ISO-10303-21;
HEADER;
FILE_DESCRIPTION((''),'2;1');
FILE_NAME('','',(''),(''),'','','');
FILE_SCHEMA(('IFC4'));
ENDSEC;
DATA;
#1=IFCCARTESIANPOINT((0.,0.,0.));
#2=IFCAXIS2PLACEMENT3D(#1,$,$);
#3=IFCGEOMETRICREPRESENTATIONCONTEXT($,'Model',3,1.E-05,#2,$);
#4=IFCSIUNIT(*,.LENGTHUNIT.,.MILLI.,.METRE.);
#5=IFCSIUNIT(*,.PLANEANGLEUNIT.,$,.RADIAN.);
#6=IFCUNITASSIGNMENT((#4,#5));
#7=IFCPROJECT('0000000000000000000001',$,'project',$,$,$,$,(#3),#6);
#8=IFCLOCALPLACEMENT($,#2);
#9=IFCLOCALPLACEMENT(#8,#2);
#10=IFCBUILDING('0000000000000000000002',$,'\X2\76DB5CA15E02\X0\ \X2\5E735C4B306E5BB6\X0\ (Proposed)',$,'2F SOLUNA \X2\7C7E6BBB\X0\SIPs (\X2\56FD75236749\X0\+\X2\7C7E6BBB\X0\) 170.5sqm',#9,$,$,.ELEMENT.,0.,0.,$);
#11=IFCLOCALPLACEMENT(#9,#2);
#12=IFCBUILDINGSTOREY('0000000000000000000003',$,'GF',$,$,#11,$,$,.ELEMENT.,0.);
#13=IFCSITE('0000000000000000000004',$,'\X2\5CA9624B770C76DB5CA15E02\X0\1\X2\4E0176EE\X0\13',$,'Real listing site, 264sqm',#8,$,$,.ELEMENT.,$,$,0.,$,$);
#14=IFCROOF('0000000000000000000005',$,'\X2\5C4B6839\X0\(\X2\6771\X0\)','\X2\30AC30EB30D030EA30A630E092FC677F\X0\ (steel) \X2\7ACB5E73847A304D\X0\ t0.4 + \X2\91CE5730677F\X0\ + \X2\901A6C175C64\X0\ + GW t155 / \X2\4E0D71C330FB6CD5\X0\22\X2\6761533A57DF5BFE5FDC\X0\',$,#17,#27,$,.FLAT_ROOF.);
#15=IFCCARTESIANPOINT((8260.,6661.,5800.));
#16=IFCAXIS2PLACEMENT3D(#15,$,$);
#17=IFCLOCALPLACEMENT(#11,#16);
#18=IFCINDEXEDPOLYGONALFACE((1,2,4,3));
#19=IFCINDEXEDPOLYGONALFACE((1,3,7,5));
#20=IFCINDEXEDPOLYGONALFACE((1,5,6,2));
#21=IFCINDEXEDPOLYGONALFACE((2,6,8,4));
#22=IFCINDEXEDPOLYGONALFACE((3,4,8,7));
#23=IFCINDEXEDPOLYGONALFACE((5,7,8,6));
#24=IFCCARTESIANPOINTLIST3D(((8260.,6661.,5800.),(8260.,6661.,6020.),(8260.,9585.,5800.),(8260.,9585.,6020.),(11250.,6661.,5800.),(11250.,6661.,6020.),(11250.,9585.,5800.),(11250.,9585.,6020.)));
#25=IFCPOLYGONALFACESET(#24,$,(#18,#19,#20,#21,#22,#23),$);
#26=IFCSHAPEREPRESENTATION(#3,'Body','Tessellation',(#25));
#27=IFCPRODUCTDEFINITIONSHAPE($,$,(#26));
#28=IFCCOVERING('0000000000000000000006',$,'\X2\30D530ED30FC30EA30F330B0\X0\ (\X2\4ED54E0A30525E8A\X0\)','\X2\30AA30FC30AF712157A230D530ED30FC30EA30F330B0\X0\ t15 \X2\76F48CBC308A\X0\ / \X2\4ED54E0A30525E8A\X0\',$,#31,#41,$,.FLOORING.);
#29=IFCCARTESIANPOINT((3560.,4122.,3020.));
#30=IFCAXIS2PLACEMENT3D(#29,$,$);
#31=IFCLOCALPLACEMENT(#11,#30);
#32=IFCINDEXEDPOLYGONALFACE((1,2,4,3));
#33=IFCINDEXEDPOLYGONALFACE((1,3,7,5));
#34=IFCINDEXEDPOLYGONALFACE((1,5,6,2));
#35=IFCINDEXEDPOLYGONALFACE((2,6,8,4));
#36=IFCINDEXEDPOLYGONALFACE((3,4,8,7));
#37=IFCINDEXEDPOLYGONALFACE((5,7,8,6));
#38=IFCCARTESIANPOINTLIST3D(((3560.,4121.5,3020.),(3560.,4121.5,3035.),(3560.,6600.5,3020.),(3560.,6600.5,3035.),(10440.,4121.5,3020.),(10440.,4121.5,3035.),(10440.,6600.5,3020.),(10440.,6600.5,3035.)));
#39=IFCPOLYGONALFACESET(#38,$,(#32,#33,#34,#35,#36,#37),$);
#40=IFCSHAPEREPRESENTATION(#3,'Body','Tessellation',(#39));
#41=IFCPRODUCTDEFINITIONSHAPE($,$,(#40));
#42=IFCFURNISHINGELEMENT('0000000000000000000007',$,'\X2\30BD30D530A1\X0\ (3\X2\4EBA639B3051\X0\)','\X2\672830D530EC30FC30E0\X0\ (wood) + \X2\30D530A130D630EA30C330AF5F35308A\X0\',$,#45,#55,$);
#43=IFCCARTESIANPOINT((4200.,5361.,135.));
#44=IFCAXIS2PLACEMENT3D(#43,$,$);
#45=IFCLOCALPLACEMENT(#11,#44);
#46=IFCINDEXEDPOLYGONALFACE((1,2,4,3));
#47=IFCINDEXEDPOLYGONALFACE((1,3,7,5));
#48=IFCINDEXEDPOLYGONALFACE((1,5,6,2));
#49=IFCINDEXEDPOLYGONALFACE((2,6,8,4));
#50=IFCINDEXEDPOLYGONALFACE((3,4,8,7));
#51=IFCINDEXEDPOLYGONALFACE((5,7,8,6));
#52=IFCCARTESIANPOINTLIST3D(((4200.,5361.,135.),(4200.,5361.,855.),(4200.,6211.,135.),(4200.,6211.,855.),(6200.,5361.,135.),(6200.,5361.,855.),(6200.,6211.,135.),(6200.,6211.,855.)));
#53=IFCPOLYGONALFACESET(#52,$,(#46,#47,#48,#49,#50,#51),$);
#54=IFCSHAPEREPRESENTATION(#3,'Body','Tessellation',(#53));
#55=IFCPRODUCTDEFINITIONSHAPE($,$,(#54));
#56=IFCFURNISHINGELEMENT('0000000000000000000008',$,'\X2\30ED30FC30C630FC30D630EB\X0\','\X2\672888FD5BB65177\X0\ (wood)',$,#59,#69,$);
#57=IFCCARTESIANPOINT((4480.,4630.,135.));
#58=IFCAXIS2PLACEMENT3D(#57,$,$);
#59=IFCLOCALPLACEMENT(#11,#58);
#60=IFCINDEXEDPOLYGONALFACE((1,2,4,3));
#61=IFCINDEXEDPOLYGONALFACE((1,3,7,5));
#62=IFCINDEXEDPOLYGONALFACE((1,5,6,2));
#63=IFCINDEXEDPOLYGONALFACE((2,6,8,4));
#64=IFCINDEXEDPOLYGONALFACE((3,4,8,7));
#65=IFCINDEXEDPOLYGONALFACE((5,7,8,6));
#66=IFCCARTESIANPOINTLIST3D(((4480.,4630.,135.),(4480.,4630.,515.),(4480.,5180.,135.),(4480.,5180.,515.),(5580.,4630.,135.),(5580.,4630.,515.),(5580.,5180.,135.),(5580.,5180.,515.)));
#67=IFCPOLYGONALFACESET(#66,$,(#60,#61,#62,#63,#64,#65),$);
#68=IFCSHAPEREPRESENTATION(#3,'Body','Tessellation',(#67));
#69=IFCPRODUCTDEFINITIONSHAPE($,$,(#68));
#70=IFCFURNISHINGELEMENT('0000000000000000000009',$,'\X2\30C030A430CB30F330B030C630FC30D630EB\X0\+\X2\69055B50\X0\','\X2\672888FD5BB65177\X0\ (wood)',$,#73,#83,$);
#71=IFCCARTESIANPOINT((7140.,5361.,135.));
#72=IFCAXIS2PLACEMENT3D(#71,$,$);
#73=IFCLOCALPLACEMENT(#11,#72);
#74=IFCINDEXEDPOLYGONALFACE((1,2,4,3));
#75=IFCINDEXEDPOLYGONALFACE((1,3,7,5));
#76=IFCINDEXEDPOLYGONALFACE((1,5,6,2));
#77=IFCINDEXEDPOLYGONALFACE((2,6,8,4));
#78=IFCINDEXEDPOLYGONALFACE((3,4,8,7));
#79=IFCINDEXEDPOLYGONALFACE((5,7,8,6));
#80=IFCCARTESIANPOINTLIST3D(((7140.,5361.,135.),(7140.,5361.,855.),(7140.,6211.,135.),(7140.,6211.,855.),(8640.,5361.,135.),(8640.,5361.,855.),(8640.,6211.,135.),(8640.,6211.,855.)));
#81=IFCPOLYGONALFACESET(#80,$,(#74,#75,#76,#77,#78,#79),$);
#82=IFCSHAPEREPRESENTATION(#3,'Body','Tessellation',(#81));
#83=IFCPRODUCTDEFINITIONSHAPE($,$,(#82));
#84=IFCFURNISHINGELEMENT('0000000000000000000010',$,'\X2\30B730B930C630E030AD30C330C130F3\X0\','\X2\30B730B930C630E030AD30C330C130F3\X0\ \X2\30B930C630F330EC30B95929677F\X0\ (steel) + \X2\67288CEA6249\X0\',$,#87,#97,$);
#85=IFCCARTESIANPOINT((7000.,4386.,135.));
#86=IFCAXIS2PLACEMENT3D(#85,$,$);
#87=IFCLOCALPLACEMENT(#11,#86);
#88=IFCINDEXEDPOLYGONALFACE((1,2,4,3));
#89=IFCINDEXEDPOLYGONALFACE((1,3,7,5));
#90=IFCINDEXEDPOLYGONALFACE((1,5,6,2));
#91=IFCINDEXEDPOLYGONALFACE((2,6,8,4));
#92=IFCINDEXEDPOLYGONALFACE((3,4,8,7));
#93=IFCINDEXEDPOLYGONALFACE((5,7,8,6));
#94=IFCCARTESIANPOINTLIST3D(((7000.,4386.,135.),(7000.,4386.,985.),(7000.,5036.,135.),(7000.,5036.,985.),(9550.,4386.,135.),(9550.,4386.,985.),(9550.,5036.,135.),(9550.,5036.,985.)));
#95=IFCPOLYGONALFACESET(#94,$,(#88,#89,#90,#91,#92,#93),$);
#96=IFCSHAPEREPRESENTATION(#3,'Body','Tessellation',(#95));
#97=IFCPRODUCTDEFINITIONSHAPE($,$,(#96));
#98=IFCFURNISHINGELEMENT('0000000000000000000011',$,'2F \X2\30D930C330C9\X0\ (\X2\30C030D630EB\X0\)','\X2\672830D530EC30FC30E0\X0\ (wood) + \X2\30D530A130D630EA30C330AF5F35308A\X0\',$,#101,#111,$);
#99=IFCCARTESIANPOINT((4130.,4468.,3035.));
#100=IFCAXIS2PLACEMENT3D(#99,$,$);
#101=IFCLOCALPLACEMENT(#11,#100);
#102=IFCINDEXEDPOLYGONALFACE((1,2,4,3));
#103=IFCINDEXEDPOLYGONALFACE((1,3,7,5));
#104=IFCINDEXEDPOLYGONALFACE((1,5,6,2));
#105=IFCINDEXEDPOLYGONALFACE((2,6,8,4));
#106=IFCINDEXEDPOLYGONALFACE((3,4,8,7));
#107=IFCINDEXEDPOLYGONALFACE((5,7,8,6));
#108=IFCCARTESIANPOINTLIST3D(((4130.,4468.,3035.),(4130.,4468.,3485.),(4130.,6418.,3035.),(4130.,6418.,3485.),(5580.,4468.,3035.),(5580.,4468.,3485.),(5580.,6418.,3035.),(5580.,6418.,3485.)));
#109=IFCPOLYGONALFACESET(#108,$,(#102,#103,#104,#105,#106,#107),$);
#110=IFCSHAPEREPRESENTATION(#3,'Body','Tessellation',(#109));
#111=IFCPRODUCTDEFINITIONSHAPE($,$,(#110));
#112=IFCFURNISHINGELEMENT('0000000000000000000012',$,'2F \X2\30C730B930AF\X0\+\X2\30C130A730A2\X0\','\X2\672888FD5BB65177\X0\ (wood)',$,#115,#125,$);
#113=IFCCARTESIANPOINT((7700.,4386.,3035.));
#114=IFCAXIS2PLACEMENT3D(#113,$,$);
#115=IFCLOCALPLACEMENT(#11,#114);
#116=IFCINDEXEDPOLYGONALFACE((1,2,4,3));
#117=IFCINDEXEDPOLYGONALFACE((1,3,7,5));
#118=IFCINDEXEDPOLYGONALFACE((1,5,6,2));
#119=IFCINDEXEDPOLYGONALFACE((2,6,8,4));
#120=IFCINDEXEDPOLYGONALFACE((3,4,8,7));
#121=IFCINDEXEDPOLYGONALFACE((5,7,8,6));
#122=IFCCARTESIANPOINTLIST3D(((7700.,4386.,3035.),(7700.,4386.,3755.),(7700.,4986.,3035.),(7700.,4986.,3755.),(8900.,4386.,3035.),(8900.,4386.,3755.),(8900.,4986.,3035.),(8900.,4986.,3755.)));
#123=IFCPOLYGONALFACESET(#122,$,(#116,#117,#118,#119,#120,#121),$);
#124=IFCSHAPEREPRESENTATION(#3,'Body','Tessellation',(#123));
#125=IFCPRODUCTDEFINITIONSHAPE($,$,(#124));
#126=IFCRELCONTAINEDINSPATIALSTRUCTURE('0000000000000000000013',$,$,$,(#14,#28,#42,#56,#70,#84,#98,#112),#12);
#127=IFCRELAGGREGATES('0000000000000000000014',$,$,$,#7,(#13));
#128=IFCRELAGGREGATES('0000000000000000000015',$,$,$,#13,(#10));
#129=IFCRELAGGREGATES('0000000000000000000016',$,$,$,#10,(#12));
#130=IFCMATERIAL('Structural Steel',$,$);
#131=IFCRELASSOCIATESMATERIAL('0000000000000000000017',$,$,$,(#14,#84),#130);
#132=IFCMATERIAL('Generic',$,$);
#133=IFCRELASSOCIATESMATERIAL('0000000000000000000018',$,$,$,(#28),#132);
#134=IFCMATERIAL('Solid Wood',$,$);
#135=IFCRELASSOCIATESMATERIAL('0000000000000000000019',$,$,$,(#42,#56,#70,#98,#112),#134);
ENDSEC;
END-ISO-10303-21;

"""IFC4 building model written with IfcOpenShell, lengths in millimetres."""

from ifc_helpers import new_model, si_unit, frame, frame_2d, origin, place, context, project, spatial, rectangle, extrude, material, element, save


model = new_model("IFC4")

# Units and contexts
model_context = context("Model", 3, precision=1e-05, world=origin())
ifc_project = project(units=[si_unit("LENGTHUNIT", "METRE", prefix="MILLI"), si_unit("PLANEANGLEUNIT", "RADIAN")], contexts=[model_context])

# Site, building, storey
site_placement = place(None, origin())
site = spatial("IfcSite", under=ifc_project, at=site_placement, Name="岩手県盛岡市1丁目13", ObjectType="Real listing site, 264sqm", CompositionType="ELEMENT", RefElevation=0.0)
building_placement = place(site_placement, origin())
building = spatial("IfcBuilding", under=site, at=building_placement, Name="盛岡市 平屋の家 (Proposed)", ObjectType="2F SOLUNA 籾殻SIPs (国産杉+籾殻) 170.5sqm", CompositionType="ELEMENT", ElevationOfRefHeight=0.0, ElevationOfTerrain=0.0)
storey_placement = place(building_placement, origin())
storey = spatial("IfcBuildingStorey", under=building, at=storey_placement, Name="GF", CompositionType="ELEMENT", Elevation=0.0)

# Shared definitions
ifc_material_1 = material(Name="Solid Wood")

# Shared definitions
ifc_material_2 = material(Name="Generic")

# Roof
ifc_material_3 = material(Name="Structural Steel")
roof_placement = place(storey_placement, frame((8260.0, 6661.0, 5800.0)))
element("IfcRoof", 1, at=roof_placement, inside=storey, material=ifc_material_3, Name="屋根(東)", Description="ガルバリウム鋼板 (steel) 立平葺き t0.4 + 野地板 + 通気層 + GW t155 / 不燃・法22条区域対応", PredefinedType="FLAT_ROOF", context=model_context, shape_type="SweptSolid", body=[
    extrude(rectangle(XDim=2990.0, YDim=2924.0, at=frame_2d((1495.0, 1462.0))), frame((8260.0, 6661.0, 5800.0)), (0.0, 0.0, 1.0), 220.0),
])

# Covering
covering_placement = place(storey_placement, frame((3560.0, 4122.0, 3020.0)))
element("IfcCovering", 2, at=covering_placement, inside=storey, material=ifc_material_2, Name="フローリング (仕上げ床)", Description="オーク無垢フローリング t15 直貼り / 仕上げ床", PredefinedType="FLOORING", context=model_context, shape_type="SweptSolid", body=[
    extrude(rectangle(XDim=6880.0, YDim=2479.0, at=frame_2d((3440.0, 1239.0))), frame((3560.0, 4122.0, 3020.0)), (0.0, 0.0, 1.0), 15.0),
])

# Furnishing elements
furnishing_1_placement = place(storey_placement, frame((4200.0, 5361.0, 135.0)))
element("IfcFurnishingElement", 3, at=furnishing_1_placement, inside=storey, material=ifc_material_1, Name="ソファ (3人掛け)", Description="木フレーム (wood) + ファブリック張り", context=model_context, shape_type="SweptSolid", body=[
    extrude(rectangle(XDim=2000.0, YDim=850.0, at=frame_2d((1000.0, 425.0))), frame((4200.0, 5361.0, 135.0)), (0.0, 0.0, 1.0), 720.0),
])
furnishing_2_placement = place(storey_placement, frame((4480.0, 4630.0, 135.0)))
element("IfcFurnishingElement", 4, at=furnishing_2_placement, inside=storey, material=ifc_material_1, Name="ローテーブル", Description="木製家具 (wood)", context=model_context, shape_type="SweptSolid", body=[
    extrude(rectangle(XDim=1100.0, YDim=550.0, at=frame_2d((550.0, 275.0))), frame((4480.0, 4630.0, 135.0)), (0.0, 0.0, 1.0), 380.0),
])
furnishing_3_placement = place(storey_placement, frame((7140.0, 5361.0, 135.0)))
element("IfcFurnishingElement", 5, at=furnishing_3_placement, inside=storey, material=ifc_material_1, Name="ダイニングテーブル+椅子", Description="木製家具 (wood)", context=model_context, shape_type="SweptSolid", body=[
    extrude(rectangle(XDim=1500.0, YDim=850.0, at=frame_2d((750.0, 425.0))), frame((7140.0, 5361.0, 135.0)), (0.0, 0.0, 1.0), 720.0),
])
furnishing_4_placement = place(storey_placement, frame((7000.0, 4386.0, 135.0)))
element("IfcFurnishingElement", 6, at=furnishing_4_placement, inside=storey, material=ifc_material_3, Name="システムキッチン", Description="システムキッチン ステンレス天板 (steel) + 木質扉", context=model_context, shape_type="SweptSolid", body=[
    extrude(rectangle(XDim=2550.0, YDim=650.0, at=frame_2d((1275.0, 325.0))), frame((7000.0, 4386.0, 135.0)), (0.0, 0.0, 1.0), 850.0),
])
furnishing_5_placement = place(storey_placement, frame((4130.0, 4468.0, 3035.0)))
element("IfcFurnishingElement", 7, at=furnishing_5_placement, inside=storey, material=ifc_material_1, Name="2F ベッド (ダブル)", Description="木フレーム (wood) + ファブリック張り", context=model_context, shape_type="SweptSolid", body=[
    extrude(rectangle(XDim=1450.0, YDim=1950.0, at=frame_2d((725.0, 975.0))), frame((4130.0, 4468.0, 3035.0)), (0.0, 0.0, 1.0), 450.0),
])
furnishing_6_placement = place(storey_placement, frame((7700.0, 4386.0, 3035.0)))
element("IfcFurnishingElement", 8, at=furnishing_6_placement, inside=storey, material=ifc_material_1, Name="2F デスク+チェア", Description="木製家具 (wood)", context=model_context, shape_type="SweptSolid", body=[
    extrude(rectangle(XDim=1200.0, YDim=600.0, at=frame_2d((600.0, 300.0))), frame((7700.0, 4386.0, 3035.0)), (0.0, 0.0, 1.0), 720.0),
])

save(model, "model.ifc")
